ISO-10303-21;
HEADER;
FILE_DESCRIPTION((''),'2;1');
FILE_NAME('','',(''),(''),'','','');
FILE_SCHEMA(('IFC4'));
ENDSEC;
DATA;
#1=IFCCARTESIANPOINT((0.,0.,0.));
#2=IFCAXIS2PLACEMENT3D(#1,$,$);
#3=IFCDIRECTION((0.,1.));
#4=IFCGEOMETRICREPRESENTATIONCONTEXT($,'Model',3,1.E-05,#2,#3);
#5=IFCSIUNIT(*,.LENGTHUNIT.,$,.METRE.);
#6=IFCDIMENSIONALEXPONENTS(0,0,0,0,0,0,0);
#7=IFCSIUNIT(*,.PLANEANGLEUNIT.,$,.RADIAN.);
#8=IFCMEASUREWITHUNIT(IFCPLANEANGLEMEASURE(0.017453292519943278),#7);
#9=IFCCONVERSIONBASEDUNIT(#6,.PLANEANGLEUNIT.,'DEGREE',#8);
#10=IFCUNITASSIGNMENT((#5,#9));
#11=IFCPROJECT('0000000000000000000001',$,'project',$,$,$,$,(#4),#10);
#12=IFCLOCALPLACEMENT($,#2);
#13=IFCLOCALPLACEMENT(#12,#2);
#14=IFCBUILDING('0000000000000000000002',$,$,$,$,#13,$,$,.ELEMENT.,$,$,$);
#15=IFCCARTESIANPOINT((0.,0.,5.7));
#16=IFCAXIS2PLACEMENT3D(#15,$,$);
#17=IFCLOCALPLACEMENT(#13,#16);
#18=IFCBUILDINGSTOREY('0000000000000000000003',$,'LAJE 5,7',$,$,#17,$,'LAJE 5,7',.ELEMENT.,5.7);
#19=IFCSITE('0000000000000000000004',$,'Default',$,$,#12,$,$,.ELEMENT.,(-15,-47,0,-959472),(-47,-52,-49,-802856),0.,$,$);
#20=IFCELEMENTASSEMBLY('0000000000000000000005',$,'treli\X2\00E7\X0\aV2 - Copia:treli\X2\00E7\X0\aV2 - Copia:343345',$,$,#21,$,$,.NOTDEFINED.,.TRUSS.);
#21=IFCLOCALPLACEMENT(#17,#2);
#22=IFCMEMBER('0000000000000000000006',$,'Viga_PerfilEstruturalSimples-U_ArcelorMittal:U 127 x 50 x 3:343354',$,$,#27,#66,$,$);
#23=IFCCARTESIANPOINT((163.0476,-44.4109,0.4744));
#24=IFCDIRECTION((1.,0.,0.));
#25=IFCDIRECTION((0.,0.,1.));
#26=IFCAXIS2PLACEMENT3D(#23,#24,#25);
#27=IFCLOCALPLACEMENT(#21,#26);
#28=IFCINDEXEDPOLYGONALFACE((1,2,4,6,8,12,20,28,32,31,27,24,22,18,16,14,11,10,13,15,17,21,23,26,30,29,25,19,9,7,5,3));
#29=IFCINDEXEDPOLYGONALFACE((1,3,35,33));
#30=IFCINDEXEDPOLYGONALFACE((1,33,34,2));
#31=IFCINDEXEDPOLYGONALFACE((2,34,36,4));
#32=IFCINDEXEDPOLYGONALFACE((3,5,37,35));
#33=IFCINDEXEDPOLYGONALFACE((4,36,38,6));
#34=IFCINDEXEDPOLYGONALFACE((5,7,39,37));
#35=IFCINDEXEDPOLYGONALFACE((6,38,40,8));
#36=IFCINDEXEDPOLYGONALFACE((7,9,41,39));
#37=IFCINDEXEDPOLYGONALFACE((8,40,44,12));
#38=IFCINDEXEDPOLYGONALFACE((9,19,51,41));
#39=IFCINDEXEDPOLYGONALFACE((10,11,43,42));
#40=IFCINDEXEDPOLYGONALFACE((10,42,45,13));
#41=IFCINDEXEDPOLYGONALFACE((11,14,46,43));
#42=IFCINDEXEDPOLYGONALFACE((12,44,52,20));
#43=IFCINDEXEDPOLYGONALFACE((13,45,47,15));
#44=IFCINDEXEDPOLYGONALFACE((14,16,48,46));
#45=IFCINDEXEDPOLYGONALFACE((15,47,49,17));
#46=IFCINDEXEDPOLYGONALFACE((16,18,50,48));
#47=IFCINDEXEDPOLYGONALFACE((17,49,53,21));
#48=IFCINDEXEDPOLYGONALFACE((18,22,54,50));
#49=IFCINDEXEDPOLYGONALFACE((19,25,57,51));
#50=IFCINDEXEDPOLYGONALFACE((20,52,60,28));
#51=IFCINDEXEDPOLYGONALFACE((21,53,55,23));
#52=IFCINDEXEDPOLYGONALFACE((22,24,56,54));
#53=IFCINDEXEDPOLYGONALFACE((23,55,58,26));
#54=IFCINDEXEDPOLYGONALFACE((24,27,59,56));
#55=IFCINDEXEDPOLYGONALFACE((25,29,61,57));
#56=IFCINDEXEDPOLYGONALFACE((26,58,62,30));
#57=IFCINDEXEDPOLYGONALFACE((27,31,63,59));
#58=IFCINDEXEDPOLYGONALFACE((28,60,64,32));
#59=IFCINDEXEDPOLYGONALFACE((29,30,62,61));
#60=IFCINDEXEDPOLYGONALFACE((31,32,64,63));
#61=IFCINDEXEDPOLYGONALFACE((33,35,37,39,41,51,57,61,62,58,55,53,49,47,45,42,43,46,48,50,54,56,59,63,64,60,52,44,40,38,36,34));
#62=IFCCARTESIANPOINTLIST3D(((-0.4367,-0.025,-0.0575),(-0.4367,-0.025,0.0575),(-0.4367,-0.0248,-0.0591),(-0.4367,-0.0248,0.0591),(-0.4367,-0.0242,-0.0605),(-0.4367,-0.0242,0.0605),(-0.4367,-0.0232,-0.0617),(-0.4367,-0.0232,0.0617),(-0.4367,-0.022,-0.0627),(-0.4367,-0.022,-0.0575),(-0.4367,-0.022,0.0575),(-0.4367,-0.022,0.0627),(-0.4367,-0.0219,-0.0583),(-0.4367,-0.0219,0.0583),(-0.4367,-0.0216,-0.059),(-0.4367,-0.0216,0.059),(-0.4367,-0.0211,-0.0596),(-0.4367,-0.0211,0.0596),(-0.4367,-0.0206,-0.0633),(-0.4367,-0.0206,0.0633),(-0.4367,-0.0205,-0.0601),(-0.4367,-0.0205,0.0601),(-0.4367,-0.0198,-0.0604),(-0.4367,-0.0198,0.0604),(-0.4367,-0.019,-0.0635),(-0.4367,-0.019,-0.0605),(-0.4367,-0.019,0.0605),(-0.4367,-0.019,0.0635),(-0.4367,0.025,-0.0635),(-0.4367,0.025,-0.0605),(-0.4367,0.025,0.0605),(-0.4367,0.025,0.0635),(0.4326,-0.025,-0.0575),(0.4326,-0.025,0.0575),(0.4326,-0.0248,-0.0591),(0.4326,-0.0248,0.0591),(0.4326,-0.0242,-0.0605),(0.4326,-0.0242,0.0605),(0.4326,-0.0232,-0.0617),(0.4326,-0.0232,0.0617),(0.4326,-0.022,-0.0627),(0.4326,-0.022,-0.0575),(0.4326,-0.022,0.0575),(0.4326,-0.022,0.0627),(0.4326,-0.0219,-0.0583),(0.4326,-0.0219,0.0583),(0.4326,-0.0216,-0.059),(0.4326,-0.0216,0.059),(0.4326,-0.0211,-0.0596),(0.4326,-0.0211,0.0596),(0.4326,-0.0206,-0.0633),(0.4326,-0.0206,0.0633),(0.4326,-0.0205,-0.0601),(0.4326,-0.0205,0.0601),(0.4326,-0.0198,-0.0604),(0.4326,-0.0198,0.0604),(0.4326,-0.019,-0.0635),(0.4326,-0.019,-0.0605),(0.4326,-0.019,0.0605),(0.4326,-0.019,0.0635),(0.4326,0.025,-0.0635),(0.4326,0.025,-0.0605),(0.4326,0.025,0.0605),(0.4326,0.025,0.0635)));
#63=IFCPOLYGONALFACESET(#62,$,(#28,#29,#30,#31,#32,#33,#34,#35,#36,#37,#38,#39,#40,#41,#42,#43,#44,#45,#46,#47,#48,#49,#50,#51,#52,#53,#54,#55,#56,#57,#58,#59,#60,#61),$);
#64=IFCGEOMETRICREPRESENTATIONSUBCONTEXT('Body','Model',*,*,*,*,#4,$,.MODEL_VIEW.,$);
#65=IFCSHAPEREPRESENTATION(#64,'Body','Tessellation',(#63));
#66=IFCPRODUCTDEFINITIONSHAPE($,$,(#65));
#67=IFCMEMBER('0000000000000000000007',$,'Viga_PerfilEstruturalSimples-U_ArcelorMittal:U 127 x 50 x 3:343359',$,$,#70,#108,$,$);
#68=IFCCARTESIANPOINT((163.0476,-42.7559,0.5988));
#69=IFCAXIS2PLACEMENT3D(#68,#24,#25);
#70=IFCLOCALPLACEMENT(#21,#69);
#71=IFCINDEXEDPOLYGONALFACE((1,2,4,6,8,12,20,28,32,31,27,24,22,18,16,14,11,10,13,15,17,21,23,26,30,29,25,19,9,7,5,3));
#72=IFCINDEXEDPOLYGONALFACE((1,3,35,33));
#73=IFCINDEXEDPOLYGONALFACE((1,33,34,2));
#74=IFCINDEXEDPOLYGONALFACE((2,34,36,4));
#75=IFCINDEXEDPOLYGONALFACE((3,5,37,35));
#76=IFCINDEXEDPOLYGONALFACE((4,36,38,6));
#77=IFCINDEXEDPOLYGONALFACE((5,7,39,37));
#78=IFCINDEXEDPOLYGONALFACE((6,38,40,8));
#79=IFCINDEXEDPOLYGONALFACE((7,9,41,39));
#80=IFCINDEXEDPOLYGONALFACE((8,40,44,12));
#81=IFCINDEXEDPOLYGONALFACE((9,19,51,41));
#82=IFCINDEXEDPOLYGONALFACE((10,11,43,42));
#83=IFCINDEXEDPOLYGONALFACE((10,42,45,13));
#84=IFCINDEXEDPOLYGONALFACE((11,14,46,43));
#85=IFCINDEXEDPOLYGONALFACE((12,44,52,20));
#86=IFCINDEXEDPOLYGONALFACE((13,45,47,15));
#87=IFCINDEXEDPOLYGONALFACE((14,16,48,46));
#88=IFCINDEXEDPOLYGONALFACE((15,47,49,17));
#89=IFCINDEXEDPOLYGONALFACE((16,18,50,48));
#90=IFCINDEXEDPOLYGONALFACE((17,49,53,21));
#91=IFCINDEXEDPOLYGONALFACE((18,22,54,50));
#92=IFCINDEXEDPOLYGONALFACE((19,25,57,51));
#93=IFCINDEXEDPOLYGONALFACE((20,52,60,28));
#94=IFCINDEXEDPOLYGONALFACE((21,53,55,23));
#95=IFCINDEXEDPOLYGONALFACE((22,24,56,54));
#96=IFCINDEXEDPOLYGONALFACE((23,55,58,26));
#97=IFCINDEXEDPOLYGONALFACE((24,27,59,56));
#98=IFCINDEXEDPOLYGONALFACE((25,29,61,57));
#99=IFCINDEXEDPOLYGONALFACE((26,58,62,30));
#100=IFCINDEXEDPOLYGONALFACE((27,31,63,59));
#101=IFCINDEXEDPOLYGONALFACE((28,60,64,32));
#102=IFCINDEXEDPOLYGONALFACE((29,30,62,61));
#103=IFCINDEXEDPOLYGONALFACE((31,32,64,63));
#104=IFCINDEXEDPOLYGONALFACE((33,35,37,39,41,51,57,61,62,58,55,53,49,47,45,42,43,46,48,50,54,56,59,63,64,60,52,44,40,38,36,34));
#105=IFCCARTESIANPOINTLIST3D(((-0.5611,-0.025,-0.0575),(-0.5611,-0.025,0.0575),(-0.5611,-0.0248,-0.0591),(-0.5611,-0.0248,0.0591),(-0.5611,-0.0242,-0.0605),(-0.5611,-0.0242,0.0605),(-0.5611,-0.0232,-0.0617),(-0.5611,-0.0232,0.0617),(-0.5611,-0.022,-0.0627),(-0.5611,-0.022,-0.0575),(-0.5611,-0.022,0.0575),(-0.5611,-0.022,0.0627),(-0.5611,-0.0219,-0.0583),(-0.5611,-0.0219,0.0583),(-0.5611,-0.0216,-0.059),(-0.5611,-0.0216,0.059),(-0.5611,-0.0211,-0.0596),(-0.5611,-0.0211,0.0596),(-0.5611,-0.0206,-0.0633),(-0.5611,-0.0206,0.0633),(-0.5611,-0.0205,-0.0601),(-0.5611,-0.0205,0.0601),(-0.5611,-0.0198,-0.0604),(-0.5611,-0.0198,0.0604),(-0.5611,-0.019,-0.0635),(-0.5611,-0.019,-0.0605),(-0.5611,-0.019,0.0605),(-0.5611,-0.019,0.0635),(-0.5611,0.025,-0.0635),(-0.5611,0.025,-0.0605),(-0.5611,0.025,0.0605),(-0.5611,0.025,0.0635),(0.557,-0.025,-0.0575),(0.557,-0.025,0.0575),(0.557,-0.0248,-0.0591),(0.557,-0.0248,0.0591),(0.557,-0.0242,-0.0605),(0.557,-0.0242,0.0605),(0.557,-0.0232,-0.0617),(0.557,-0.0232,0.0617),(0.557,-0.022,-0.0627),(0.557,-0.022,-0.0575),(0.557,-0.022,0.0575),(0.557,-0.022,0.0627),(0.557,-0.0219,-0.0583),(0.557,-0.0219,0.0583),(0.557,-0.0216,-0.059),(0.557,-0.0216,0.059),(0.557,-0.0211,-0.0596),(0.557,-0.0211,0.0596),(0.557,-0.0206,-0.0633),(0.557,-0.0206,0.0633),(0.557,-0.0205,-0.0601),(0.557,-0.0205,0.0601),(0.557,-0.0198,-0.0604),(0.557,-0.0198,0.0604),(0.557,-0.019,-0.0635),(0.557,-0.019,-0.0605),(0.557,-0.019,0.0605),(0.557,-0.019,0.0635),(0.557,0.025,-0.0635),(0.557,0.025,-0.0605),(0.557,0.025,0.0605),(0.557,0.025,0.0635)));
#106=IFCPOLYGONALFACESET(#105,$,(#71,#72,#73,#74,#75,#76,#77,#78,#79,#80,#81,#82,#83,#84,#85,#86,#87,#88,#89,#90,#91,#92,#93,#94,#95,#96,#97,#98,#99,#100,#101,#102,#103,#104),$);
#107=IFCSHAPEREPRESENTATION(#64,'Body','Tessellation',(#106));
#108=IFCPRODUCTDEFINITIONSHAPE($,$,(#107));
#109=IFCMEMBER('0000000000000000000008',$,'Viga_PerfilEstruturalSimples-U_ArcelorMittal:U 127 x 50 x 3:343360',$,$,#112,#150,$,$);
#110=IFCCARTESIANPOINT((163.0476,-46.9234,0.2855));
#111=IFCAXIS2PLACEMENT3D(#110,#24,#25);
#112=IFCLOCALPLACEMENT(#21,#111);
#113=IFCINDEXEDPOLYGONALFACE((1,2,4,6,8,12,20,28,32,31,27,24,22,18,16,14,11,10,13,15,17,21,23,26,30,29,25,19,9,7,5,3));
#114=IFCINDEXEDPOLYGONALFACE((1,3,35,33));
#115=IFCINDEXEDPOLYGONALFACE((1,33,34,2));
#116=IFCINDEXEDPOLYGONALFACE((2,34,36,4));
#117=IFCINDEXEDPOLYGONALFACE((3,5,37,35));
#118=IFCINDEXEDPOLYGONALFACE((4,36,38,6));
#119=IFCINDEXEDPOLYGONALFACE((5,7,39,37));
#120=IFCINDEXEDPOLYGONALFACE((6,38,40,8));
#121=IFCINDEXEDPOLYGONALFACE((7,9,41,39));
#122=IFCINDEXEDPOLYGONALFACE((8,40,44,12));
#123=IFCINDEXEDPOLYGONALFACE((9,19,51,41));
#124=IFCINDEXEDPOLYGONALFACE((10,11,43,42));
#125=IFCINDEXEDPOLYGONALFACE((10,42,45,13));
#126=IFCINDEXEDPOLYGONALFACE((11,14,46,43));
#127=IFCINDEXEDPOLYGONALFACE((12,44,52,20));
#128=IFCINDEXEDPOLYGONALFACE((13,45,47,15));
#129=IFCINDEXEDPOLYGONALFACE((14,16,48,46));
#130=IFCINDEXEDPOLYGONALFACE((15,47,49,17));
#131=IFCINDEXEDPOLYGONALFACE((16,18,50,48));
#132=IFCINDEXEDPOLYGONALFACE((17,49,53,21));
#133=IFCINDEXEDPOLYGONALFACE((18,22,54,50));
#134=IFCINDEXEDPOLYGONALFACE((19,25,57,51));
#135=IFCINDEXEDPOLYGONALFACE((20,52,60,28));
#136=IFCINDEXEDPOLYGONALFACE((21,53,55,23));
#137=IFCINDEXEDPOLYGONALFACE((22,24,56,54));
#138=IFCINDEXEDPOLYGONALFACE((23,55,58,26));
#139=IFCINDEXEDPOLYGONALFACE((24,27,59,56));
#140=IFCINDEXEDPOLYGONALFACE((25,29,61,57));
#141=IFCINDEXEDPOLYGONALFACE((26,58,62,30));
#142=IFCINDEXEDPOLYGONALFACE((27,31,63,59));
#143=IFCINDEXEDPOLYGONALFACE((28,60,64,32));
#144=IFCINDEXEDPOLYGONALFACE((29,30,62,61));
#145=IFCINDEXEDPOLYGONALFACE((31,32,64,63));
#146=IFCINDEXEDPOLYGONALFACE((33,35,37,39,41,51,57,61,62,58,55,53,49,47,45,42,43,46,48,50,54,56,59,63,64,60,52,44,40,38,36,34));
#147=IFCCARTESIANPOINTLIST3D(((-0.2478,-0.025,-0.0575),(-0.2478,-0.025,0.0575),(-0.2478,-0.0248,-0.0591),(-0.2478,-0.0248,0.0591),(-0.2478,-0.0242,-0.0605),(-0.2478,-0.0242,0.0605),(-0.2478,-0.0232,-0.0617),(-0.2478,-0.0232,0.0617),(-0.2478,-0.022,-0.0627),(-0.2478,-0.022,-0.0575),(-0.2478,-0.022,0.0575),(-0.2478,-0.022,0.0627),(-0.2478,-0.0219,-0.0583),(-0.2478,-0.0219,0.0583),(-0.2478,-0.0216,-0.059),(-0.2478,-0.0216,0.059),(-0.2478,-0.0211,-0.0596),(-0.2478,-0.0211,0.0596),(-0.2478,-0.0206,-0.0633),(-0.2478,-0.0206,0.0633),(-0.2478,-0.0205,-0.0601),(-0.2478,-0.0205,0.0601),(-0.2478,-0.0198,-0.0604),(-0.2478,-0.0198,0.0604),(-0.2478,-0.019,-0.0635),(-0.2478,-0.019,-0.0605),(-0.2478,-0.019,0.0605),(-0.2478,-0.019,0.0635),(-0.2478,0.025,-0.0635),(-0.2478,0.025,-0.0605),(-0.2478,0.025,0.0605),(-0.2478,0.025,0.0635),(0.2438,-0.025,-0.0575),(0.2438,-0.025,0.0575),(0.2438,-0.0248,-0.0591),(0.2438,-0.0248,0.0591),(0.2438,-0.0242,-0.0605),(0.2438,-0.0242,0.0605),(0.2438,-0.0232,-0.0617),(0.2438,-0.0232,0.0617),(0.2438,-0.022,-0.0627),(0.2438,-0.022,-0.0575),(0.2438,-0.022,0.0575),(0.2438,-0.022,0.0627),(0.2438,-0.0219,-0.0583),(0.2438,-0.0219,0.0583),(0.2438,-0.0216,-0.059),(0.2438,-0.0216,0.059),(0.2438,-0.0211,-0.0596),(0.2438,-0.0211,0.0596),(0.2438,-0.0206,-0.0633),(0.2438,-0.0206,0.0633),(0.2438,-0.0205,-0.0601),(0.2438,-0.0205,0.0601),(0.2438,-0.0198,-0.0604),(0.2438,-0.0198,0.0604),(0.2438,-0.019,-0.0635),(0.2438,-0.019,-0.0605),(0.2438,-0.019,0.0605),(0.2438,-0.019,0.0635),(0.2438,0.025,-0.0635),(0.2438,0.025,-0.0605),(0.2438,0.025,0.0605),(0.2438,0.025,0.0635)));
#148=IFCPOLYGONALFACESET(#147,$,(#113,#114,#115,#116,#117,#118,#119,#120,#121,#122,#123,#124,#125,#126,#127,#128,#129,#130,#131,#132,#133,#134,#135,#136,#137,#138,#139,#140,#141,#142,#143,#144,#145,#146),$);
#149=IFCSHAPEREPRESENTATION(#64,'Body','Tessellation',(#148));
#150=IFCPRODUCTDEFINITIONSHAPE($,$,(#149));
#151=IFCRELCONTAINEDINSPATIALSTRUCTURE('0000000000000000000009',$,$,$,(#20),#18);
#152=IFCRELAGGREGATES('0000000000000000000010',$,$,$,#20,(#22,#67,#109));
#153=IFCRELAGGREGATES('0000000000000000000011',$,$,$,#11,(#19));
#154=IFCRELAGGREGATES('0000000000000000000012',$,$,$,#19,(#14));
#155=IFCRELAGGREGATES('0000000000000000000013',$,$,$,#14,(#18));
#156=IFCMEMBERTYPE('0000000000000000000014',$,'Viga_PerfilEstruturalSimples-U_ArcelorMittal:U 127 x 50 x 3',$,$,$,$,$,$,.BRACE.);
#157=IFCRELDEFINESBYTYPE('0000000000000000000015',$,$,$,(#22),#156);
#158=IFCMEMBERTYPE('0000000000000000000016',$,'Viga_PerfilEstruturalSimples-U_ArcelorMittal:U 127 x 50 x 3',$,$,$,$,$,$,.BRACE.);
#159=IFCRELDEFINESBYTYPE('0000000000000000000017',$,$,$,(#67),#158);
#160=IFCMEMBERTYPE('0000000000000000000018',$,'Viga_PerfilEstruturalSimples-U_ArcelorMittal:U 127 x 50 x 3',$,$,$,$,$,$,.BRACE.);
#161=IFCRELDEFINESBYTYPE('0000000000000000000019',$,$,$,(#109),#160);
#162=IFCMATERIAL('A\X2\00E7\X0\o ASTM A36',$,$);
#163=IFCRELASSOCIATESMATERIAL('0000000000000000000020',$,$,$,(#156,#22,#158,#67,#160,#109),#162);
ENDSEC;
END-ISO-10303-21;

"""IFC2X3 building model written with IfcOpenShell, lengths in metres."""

from ifc_helpers import new_model, entity, si_unit, converted_unit, direction, frame, frame_2d, origin, place, context, subcontext, project, spatial, polyline, circle_curve, parameter, trimmed, segment, composite_curve, outline, extrude, source, transform, mapped, material, type_object, type_shapes, element, aggregate, save


model = new_model("IFC2X3")

# Units and contexts
model_context = context("Model", 3, precision=1e-05, world=origin(), true_north=direction((0.0, 1.0)))
body_context = subcontext(model_context, "Body", "Model", "MODEL_VIEW")
ifc_project = project(units=[si_unit("LENGTHUNIT", "METRE"), converted_unit("PLANEANGLEUNIT", "DEGREE", entity("IfcPlaneAngleMeasure", 0.017453292519943278), si_unit("PLANEANGLEUNIT", "RADIAN"), dimensions=[0, 0, 0, 0, 0, 0, 0])], contexts=[model_context])

# Site, building, storey
site_placement = place(None, origin())
site = spatial("IfcSite", under=ifc_project, at=site_placement, Name="Default", CompositionType="ELEMENT", RefLatitude=(-15, -47, 0, -959472), RefLongitude=(-47, -52, -49, -802856), RefElevation=0.0)
building_placement = place(site_placement, origin())
building = spatial("IfcBuilding", under=site, at=building_placement, CompositionType="ELEMENT")
storey_placement = place(building_placement, frame((0.0, 0.0, 5.7)))
storey = spatial("IfcBuildingStorey", under=building, at=storey_placement, Name="LAJE 5,7", LongName="LAJE 5,7", CompositionType="ELEMENT", Elevation=5.7)

# Element assembly, members
assembly_1_placement = place(storey_placement, origin())
assembly_1 = element("IfcElementAssembly", 1, at=assembly_1_placement, inside=storey, Name="treliçaV2 - Copia:treliçaV2 - Copia:343345", AssemblyPlace="NOTDEFINED", PredefinedType="TRUSS")
ifc_material = material(Name="Aço ASTM A36")
member_type_1 = type_object("IfcMemberType", Name="Viga_PerfilEstruturalSimples-U_ArcelorMittal:U 127 x 50 x 3", PredefinedType="BRACE", material=ifc_material)
shared_shape_1 = source(origin(), body_context, "Body", "SweptSolid", [
    extrude(outline(composite_curve([segment(polyline([(-0.0575, -0.0192), (0.0575, -0.0192)]), True, "CONTINUOUS"), segment(trimmed(circle_curve(frame_2d((0.0575, -0.0132), x_axis=(0.0, 1.0)), 0.006), [parameter(180.0)], [parameter(270.0)], True, "PARAMETER"), True, "CONTINUOUS"), segment(polyline([(0.0635, -0.0132), (0.0635, 0.0308)]), True, "CONTINUOUS"), segment(polyline([(0.0635, 0.0308), (0.0605, 0.0308)]), True, "CONTINUOUS"), segment(polyline([(0.0605, 0.0308), (0.0605, -0.0132)]), True, "CONTINUOUS"), segment(trimmed(circle_curve(frame_2d((0.0575, -0.0132), x_axis=(0.0, 1.0)), 0.003), [parameter(180.0)], [parameter(270.0)], True, "PARAMETER"), False, "CONTINUOUS"), segment(polyline([(0.0575, -0.0162), (-0.0575, -0.0162)]), True, "CONTINUOUS"), segment(trimmed(circle_curve(frame_2d((-0.0575, -0.0132), x_axis=(0.0, 1.0)), 0.003), [parameter(90.0)], [parameter(180.0)], True, "PARAMETER"), False, "CONTINUOUS"), segment(polyline([(-0.0605, -0.0132), (-0.0605, 0.0308)]), True, "CONTINUOUS"), segment(polyline([(-0.0605, 0.0308), (-0.0635, 0.0308)]), True, "CONTINUOUS"), segment(polyline([(-0.0635, 0.0308), (-0.0635, -0.0132)]), True, "CONTINUOUS"), segment(trimmed(circle_curve(frame_2d((-0.0575, -0.0132), x_axis=(0.0, 1.0)), 0.006), [parameter(90.0)], [parameter(180.0)], True, "PARAMETER"), True, "CONTINUOUS")], self_intersect=False)), frame((-0.4367, -0.0058, 0.0), z_axis=(1.0, 0.0, 0.0), x_axis=(0.0, 0.0, -1.0)), (0.0, 0.0, 1.0), 0.8693),
])
type_shapes(member_type_1, [shared_shape_1])
member_1_placement = place(assembly_1_placement, frame((163.0476, -44.4109, 0.4744), z_axis=(1.0, 0.0, 0.0), x_axis=(0.0, 0.0, 1.0)))
member_1 = element("IfcMember", 2, at=member_1_placement, type_object=member_type_1, material=ifc_material, Name="Viga_PerfilEstruturalSimples-U_ArcelorMittal:U 127 x 50 x 3:343354", context=body_context, shape_type="MappedRepresentation", body=[
    mapped(shared_shape_1, transform((0.0, 0.0, 0.0), scale=1.0)),
])
member_type_2 = type_object("IfcMemberType", Name="Viga_PerfilEstruturalSimples-U_ArcelorMittal:U 127 x 50 x 3", PredefinedType="BRACE", material=ifc_material)
shared_shape_2 = source(origin(), body_context, "Body", "SweptSolid", [
    extrude(outline(composite_curve([segment(polyline([(-0.0575, -0.0192), (0.0575, -0.0192)]), True, "CONTINUOUS"), segment(trimmed(circle_curve(frame_2d((0.0575, -0.0132), x_axis=(0.0, 1.0)), 0.006), [parameter(180.0)], [parameter(270.0)], True, "PARAMETER"), True, "CONTINUOUS"), segment(polyline([(0.0635, -0.0132), (0.0635, 0.0308)]), True, "CONTINUOUS"), segment(polyline([(0.0635, 0.0308), (0.0605, 0.0308)]), True, "CONTINUOUS"), segment(polyline([(0.0605, 0.0308), (0.0605, -0.0132)]), True, "CONTINUOUS"), segment(trimmed(circle_curve(frame_2d((0.0575, -0.0132), x_axis=(0.0, 1.0)), 0.003), [parameter(180.0)], [parameter(270.0)], True, "PARAMETER"), False, "CONTINUOUS"), segment(polyline([(0.0575, -0.0162), (-0.0575, -0.0162)]), True, "CONTINUOUS"), segment(trimmed(circle_curve(frame_2d((-0.0575, -0.0132), x_axis=(0.0, 1.0)), 0.003), [parameter(90.0)], [parameter(180.0)], True, "PARAMETER"), False, "CONTINUOUS"), segment(polyline([(-0.0605, -0.0132), (-0.0605, 0.0308)]), True, "CONTINUOUS"), segment(polyline([(-0.0605, 0.0308), (-0.0635, 0.0308)]), True, "CONTINUOUS"), segment(polyline([(-0.0635, 0.0308), (-0.0635, -0.0132)]), True, "CONTINUOUS"), segment(trimmed(circle_curve(frame_2d((-0.0575, -0.0132), x_axis=(0.0, 1.0)), 0.006), [parameter(90.0)], [parameter(180.0)], True, "PARAMETER"), True, "CONTINUOUS")], self_intersect=False)), frame((-0.5611, -0.0058, 0.0), z_axis=(1.0, 0.0, 0.0), x_axis=(0.0, 0.0, -1.0)), (0.0, 0.0, 1.0), 1.1181),
])
type_shapes(member_type_2, [shared_shape_2])
member_2_placement = place(assembly_1_placement, frame((163.0476, -42.7559, 0.5988), z_axis=(1.0, 0.0, 0.0), x_axis=(0.0, 0.0, 1.0)))
member_2 = element("IfcMember", 3, at=member_2_placement, type_object=member_type_2, material=ifc_material, Name="Viga_PerfilEstruturalSimples-U_ArcelorMittal:U 127 x 50 x 3:343359", context=body_context, shape_type="MappedRepresentation", body=[
    mapped(shared_shape_2, transform((0.0, 0.0, 0.0), scale=1.0)),
])

# Shared definitions
member_type_3 = type_object("IfcMemberType", Name="Viga_PerfilEstruturalSimples-U_ArcelorMittal:U 127 x 50 x 3", PredefinedType="BRACE", material=ifc_material)
shared_shape_3 = source(origin(), body_context, "Body", "SweptSolid", [
    extrude(outline(composite_curve([segment(polyline([(-0.0575, -0.0192), (0.0575, -0.0192)]), True, "CONTINUOUS"), segment(trimmed(circle_curve(frame_2d((0.0575, -0.0132), x_axis=(0.0, 1.0)), 0.006), [parameter(180.0)], [parameter(270.0)], True, "PARAMETER"), True, "CONTINUOUS"), segment(polyline([(0.0635, -0.0132), (0.0635, 0.0308)]), True, "CONTINUOUS"), segment(polyline([(0.0635, 0.0308), (0.0605, 0.0308)]), True, "CONTINUOUS"), segment(polyline([(0.0605, 0.0308), (0.0605, -0.0132)]), True, "CONTINUOUS"), segment(trimmed(circle_curve(frame_2d((0.0575, -0.0132), x_axis=(0.0, 1.0)), 0.003), [parameter(180.0)], [parameter(270.0)], True, "PARAMETER"), False, "CONTINUOUS"), segment(polyline([(0.0575, -0.0162), (-0.0575, -0.0162)]), True, "CONTINUOUS"), segment(trimmed(circle_curve(frame_2d((-0.0575, -0.0132), x_axis=(0.0, 1.0)), 0.003), [parameter(90.0)], [parameter(180.0)], True, "PARAMETER"), False, "CONTINUOUS"), segment(polyline([(-0.0605, -0.0132), (-0.0605, 0.0308)]), True, "CONTINUOUS"), segment(polyline([(-0.0605, 0.0308), (-0.0635, 0.0308)]), True, "CONTINUOUS"), segment(polyline([(-0.0635, 0.0308), (-0.0635, -0.0132)]), True, "CONTINUOUS"), segment(trimmed(circle_curve(frame_2d((-0.0575, -0.0132), x_axis=(0.0, 1.0)), 0.006), [parameter(90.0)], [parameter(180.0)], True, "PARAMETER"), True, "CONTINUOUS")], self_intersect=False)), frame((-0.2478, -0.0058, 0.0), z_axis=(1.0, 0.0, 0.0), x_axis=(0.0, 0.0, -1.0)), (0.0, 0.0, 1.0), 0.4916),
])
type_shapes(member_type_3, [shared_shape_3])

# Member
member_3_placement = place(assembly_1_placement, frame((163.0476, -46.9234, 0.2855), z_axis=(1.0, 0.0, 0.0), x_axis=(0.0, 0.0, 1.0)))
member_3 = element("IfcMember", 4, at=member_3_placement, type_object=member_type_3, material=ifc_material, Name="Viga_PerfilEstruturalSimples-U_ArcelorMittal:U 127 x 50 x 3:343360", context=body_context, shape_type="MappedRepresentation", body=[
    mapped(shared_shape_3, transform((0.0, 0.0, 0.0), scale=1.0)),
])
aggregate(assembly_1, [member_1, member_2, member_3])

save(model, "model.ifc")
